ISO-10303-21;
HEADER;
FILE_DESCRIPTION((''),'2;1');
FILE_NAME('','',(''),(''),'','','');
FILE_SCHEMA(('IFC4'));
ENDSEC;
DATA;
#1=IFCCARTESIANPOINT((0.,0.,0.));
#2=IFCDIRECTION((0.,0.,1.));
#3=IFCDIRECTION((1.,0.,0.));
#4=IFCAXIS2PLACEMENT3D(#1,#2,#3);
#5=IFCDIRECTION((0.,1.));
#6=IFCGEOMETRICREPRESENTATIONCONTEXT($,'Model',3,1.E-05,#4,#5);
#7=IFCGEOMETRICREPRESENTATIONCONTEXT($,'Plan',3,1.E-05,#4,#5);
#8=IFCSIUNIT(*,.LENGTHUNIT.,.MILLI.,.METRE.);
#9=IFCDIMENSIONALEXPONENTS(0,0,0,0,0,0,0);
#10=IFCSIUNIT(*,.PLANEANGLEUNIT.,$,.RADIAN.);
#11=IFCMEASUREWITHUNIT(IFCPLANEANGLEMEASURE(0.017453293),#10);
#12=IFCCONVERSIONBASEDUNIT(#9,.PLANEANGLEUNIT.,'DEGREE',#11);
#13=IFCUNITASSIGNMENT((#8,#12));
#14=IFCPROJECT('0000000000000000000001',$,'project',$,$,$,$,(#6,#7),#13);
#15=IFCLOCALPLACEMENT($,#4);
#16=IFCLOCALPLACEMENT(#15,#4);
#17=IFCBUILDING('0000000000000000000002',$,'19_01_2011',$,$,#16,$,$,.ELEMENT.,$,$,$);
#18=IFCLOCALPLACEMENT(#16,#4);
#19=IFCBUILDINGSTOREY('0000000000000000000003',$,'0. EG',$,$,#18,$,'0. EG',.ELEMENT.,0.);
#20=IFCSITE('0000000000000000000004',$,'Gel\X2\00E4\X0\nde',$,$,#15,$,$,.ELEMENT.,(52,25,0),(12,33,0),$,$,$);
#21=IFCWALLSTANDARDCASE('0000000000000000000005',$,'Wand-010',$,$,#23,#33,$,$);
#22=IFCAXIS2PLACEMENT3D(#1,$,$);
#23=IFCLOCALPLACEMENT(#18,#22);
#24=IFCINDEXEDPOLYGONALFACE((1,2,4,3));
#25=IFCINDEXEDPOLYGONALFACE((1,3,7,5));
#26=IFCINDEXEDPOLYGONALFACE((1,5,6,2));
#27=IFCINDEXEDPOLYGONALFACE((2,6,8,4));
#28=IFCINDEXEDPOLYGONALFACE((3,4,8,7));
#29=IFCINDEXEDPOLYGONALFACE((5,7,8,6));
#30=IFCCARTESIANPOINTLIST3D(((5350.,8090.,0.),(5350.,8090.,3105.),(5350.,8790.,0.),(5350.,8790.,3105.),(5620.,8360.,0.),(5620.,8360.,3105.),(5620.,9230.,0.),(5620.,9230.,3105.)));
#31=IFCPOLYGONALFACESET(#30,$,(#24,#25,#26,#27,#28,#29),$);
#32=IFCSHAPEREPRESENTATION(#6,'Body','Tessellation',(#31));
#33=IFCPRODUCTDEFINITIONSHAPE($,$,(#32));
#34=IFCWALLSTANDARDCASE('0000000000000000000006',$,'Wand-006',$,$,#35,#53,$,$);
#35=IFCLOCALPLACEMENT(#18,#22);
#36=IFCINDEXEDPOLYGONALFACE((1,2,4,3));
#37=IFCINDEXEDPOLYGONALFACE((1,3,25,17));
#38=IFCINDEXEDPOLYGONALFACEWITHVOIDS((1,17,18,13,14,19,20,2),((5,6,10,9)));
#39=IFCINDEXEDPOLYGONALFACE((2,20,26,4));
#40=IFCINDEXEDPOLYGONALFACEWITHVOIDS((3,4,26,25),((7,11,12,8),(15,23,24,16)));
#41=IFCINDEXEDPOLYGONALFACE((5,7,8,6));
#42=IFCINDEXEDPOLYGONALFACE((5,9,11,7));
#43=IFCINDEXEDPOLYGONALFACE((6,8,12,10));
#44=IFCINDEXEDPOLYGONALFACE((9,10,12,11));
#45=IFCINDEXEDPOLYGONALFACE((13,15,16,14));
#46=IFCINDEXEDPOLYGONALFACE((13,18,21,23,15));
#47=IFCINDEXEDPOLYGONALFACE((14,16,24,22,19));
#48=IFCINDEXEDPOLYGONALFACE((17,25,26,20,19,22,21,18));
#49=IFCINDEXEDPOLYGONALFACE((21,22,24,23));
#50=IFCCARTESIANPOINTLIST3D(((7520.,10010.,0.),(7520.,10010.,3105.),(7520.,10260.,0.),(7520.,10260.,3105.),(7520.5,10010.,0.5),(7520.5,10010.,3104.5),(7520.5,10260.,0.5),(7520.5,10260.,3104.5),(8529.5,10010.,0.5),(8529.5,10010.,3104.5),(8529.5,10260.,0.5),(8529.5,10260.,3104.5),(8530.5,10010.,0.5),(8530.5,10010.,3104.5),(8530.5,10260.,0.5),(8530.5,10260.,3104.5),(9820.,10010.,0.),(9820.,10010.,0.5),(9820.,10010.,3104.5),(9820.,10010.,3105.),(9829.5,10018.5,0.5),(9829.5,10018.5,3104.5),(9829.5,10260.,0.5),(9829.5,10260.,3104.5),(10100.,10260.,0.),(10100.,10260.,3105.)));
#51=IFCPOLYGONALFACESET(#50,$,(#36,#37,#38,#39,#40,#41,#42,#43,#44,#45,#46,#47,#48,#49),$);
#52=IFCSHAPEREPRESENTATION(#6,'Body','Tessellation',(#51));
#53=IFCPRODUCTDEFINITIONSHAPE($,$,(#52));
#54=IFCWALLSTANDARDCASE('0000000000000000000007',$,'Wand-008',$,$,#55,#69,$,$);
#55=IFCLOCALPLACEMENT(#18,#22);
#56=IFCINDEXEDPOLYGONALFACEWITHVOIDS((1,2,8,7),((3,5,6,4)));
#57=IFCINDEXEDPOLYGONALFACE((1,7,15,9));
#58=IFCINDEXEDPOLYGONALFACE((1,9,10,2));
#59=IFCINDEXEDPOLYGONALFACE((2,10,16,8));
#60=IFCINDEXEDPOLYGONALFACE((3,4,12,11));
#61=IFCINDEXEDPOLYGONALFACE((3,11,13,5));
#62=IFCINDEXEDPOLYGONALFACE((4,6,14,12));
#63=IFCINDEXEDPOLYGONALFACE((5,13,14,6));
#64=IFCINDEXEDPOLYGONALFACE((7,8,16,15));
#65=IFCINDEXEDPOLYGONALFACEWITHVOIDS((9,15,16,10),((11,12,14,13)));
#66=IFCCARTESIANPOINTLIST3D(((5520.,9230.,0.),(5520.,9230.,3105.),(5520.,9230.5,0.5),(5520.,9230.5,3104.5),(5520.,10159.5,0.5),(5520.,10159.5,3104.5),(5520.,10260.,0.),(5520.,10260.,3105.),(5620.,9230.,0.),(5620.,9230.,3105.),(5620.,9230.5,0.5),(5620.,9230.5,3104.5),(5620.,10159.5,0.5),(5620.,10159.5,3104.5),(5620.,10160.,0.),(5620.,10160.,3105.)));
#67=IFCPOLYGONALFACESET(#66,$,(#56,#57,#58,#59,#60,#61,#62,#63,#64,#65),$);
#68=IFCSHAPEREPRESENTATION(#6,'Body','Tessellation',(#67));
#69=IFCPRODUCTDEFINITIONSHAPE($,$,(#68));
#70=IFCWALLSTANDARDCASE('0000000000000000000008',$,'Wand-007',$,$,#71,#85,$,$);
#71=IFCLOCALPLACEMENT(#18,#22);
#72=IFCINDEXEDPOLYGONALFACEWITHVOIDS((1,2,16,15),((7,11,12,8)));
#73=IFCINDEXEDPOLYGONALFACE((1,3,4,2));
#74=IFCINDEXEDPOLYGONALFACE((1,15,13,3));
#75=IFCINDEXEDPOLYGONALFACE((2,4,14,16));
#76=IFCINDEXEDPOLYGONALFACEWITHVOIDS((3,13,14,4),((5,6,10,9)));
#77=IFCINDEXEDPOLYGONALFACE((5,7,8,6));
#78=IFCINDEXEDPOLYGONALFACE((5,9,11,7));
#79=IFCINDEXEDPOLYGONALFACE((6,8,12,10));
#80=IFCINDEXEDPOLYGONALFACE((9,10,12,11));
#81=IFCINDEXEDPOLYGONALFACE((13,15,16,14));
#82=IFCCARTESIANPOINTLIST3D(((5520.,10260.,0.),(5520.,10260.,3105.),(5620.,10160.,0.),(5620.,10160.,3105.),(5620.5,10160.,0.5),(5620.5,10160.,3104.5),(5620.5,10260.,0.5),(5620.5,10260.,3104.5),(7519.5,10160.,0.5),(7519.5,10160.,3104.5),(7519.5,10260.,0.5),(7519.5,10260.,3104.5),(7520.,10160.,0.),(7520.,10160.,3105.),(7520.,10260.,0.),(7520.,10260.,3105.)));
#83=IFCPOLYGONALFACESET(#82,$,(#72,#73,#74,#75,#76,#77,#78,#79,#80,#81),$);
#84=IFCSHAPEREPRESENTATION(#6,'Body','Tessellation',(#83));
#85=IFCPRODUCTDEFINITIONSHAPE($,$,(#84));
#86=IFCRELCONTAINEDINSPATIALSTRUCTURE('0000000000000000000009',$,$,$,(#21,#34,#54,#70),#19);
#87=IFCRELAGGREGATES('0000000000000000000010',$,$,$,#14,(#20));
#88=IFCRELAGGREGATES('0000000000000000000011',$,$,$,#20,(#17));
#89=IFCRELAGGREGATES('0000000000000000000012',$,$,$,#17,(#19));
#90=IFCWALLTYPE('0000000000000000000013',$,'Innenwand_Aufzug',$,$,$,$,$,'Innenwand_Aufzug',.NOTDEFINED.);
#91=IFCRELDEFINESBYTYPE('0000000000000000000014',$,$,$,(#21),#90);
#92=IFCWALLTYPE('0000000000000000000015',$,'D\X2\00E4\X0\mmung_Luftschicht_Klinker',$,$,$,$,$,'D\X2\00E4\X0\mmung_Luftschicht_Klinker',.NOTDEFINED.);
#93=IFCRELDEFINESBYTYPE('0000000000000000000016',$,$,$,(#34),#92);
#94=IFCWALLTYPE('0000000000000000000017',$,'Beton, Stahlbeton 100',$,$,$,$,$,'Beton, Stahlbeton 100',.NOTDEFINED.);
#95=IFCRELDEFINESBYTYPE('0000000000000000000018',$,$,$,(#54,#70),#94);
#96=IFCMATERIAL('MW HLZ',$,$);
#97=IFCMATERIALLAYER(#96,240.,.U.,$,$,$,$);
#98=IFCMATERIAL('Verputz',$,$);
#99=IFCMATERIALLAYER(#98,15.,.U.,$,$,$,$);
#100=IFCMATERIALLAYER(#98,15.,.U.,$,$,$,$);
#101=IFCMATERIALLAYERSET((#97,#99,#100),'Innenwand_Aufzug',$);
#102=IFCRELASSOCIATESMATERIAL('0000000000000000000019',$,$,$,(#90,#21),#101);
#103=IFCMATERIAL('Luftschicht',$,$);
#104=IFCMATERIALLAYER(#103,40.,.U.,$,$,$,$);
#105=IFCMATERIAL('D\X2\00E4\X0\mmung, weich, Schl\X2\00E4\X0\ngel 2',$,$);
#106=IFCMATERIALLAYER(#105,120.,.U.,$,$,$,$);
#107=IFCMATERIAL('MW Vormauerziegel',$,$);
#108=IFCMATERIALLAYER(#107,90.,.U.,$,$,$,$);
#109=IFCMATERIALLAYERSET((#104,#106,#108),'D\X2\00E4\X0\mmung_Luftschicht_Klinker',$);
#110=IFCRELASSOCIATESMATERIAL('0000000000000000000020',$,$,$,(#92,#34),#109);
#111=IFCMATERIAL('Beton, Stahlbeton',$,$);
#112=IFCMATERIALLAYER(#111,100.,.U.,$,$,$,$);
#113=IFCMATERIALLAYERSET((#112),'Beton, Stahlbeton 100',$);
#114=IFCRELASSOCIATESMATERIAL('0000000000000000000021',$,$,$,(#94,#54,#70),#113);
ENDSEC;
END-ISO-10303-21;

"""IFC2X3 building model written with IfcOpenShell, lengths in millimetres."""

from ifc_helpers import new_model, entity, si_unit, converted_unit, direction, frame, frame_2d, origin_with_axes, place, context, project, spatial, polyline, rectangle, outline, extrude, material, layer, layer_set, layer_usage, type_object, element, save


model = new_model("IFC2X3")

# Units and contexts
model_context = context("Model", 3, precision=1e-05, world=origin_with_axes(), true_north=direction((0.0, 1.0)))
plan_context = context("Plan", 3, precision=1e-05, world=origin_with_axes(), true_north=direction((0.0, 1.0)))
ifc_project = project(units=[si_unit("LENGTHUNIT", "METRE", prefix="MILLI"), converted_unit("PLANEANGLEUNIT", "DEGREE", entity("IfcPlaneAngleMeasure", 0.017453293), si_unit("PLANEANGLEUNIT", "RADIAN"), dimensions=[0, 0, 0, 0, 0, 0, 0])], contexts=[model_context, plan_context])

# Site, building, storey
site_placement = place(None, origin_with_axes())
site = spatial("IfcSite", under=ifc_project, at=site_placement, Name="Gelände", CompositionType="ELEMENT", RefLatitude=(52, 25, 0), RefLongitude=(12, 33, 0))
building_placement = place(site_placement, origin_with_axes())
building = spatial("IfcBuilding", under=site, at=building_placement, Name="19_01_2011", CompositionType="ELEMENT")
storey_placement = place(building_placement, origin_with_axes())
storey = spatial("IfcBuildingStorey", under=building, at=storey_placement, Name="0. EG", LongName="0. EG", CompositionType="ELEMENT", Elevation=0.0)

# Shared definitions
ifc_material_1 = material(Name="Beton, Stahlbeton")

# Shared definitions
ifc_material_2 = material(Name="MW Vormauerziegel")

# Shared definitions
ifc_material_3 = material(Name="Luftschicht")
ifc_material_4 = material(Name="Verputz")
ifc_material_5 = material(Name="MW HLZ")
ifc_material_6 = material(Name="Dämmung, weich, Schlängel 2")

# Wall
ifc_layer_1 = layer(ifc_material_5, 240.0, ventilated="UNKNOWN")
ifc_layer_2 = layer(ifc_material_4, 15.0, ventilated="UNKNOWN")
ifc_layer_3 = layer(ifc_material_4, 15.0, ventilated="UNKNOWN")
ifc_layer_set_1 = layer_set([ifc_layer_1, ifc_layer_2, ifc_layer_3], Name="Innenwand_Aufzug")
wall_type_1 = type_object("IfcWallType", Name="Innenwand_Aufzug", ElementType="Innenwand_Aufzug", PredefinedType="NOTDEFINED", material=ifc_layer_set_1)
ifc_layer_usage_1 = layer_usage(ifc_layer_set_1, "AXIS2", "NEGATIVE", 0.0)
wall_1_placement = place(storey_placement, frame((5620.0, 9230.0, 0.0), z_axis=(0.0, 0.0, 1.0), x_axis=(0.0, -1.0, 0.0)))
element("IfcWallStandardCase", 1, at=wall_1_placement, inside=storey, type_object=wall_type_1, material=ifc_layer_usage_1, Name="Wand-010", context=model_context, shape_type="SweptSolid", body=[
    extrude(outline(polyline([(440.0, -270.0), (1140.0, -270.0), (870.0, 0.0), (0.0, 0.0), (440.0, -270.0)])), origin_with_axes(), (0.0, 0.0, 1.0), 3105.0),
])

# Wall, openings
ifc_layer_4 = layer(ifc_material_3, 40.0, ventilated="UNKNOWN")
ifc_layer_5 = layer(ifc_material_6, 120.0, ventilated="UNKNOWN")
ifc_layer_6 = layer(ifc_material_2, 90.0, ventilated="UNKNOWN")
ifc_layer_set_2 = layer_set([ifc_layer_4, ifc_layer_5, ifc_layer_6], Name="Dämmung_Luftschicht_Klinker")
ifc_layer_usage_2 = layer_usage(ifc_layer_set_2, "AXIS2", "POSITIVE", 0.0)
wall_type_2 = type_object("IfcWallType", Name="Dämmung_Luftschicht_Klinker", ElementType="Dämmung_Luftschicht_Klinker", PredefinedType="NOTDEFINED", material=ifc_layer_set_2)
wall_2_placement = place(storey_placement, frame((10100.0, 10260.0, 0.0), z_axis=(0.0, 0.0, 1.0), x_axis=(-1.0, 0.0, 0.0)))
wall_2 = element("IfcWallStandardCase", 2, at=wall_2_placement, inside=storey, type_object=wall_type_2, material=ifc_layer_usage_2, Name="Wand-006", context=model_context, shape_type="SweptSolid", body=[
    extrude(outline(polyline([(0.0, 0.0), (2580.0, 0.0), (2580.0, 250.0), (280.0, 250.0), (0.0, 0.0)])), origin_with_axes(), (0.0, 0.0, 1.0), 3105.0),
])
opening_1_placement = place(wall_2_placement, frame((920.0, 0.0, 0.0), z_axis=(0.0, 0.0, 1.0), x_axis=(1.0, 0.0, 0.0)))
element("IfcOpeningElement", 3, at=opening_1_placement, cuts=wall_2, ObjectType="Opening", context=model_context, shape_type="SweptSolid", body=[
    extrude(rectangle(XDim=1299.0, YDim=3104.0, at=frame_2d((0.0, 1552.5), x_axis=(1.0, 0.0))), frame((0.0, 0.0, 0.0), z_axis=(0.0, 1.0, 0.0), x_axis=(-1.0, 0.0, 0.0)), (0.0, 0.0, 1.0), 250.0),
])
opening_2_placement = place(wall_2_placement, frame((2075.0, 0.0, 0.0), z_axis=(0.0, 0.0, 1.0), x_axis=(1.0, 0.0, 0.0)))
element("IfcOpeningElement", 4, at=opening_2_placement, cuts=wall_2, ObjectType="Opening", context=model_context, shape_type="SweptSolid", body=[
    extrude(rectangle(XDim=1009.0, YDim=3104.0, at=frame_2d((0.0, 1552.5), x_axis=(1.0, 0.0))), frame((0.0, 0.0, 0.0), z_axis=(0.0, 1.0, 0.0), x_axis=(-1.0, 0.0, 0.0)), (0.0, 0.0, 1.0), 250.0),
])

# Walls, openings
ifc_layer_7 = layer(ifc_material_1, 100.0, ventilated="UNKNOWN")
ifc_layer_set_3 = layer_set([ifc_layer_7], Name="Beton, Stahlbeton 100")
ifc_layer_usage_3 = layer_usage(ifc_layer_set_3, "AXIS2", "POSITIVE", 0.0)
wall_type_3 = type_object("IfcWallType", Name="Beton, Stahlbeton 100", ElementType="Beton, Stahlbeton 100", PredefinedType="NOTDEFINED", material=ifc_layer_set_3)
wall_3_placement = place(storey_placement, frame((5520.0, 10260.0, 0.0), z_axis=(0.0, 0.0, 1.0), x_axis=(0.0, -1.0, 0.0)))
wall_3 = element("IfcWallStandardCase", 5, at=wall_3_placement, inside=storey, type_object=wall_type_3, material=ifc_layer_usage_3, Name="Wand-008", context=model_context, shape_type="SweptSolid", body=[
    extrude(outline(polyline([(0.0, 0.0), (1030.0, 0.0), (1030.0, 100.0), (100.0, 100.0), (0.0, 0.0)])), origin_with_axes(), (0.0, 0.0, 1.0), 3105.0),
])
opening_3_placement = place(wall_3_placement, frame((565.0, 0.0, 0.0), z_axis=(0.0, 0.0, 1.0), x_axis=(1.0, 0.0, 0.0)))
element("IfcOpeningElement", 6, at=opening_3_placement, cuts=wall_3, ObjectType="Opening", context=model_context, shape_type="SweptSolid", body=[
    extrude(rectangle(XDim=929.0, YDim=3104.0, at=frame_2d((0.0, 1552.5), x_axis=(1.0, 0.0))), frame((0.0, 0.0, 0.0), z_axis=(0.0, 1.0, 0.0), x_axis=(-1.0, 0.0, 0.0)), (0.0, 0.0, 1.0), 100.0),
])
ifc_layer_usage_4 = layer_usage(ifc_layer_set_3, "AXIS2", "POSITIVE", 0.0)
wall_4_placement = place(storey_placement, frame((7520.0, 10260.0, 0.0), z_axis=(0.0, 0.0, 1.0), x_axis=(-1.0, 0.0, 0.0)))
wall_4 = element("IfcWallStandardCase", 7, at=wall_4_placement, inside=storey, type_object=wall_type_3, material=ifc_layer_usage_4, Name="Wand-007", context=model_context, shape_type="SweptSolid", body=[
    extrude(outline(polyline([(0.0, 0.0), (2000.0, 0.0), (1900.0, 100.0), (0.0, 100.0), (0.0, 0.0)])), origin_with_axes(), (0.0, 0.0, 1.0), 3105.0),
])
opening_4_placement = place(wall_4_placement, frame((950.0, 0.0, 0.0), z_axis=(0.0, 0.0, 1.0), x_axis=(1.0, 0.0, 0.0)))
element("IfcOpeningElement", 8, at=opening_4_placement, cuts=wall_4, ObjectType="Opening", context=model_context, shape_type="SweptSolid", body=[
    extrude(rectangle(XDim=1899.0, YDim=3104.0, at=frame_2d((0.0, 1552.5), x_axis=(1.0, 0.0))), frame((0.0, 0.0, 0.0), z_axis=(0.0, 1.0, 0.0), x_axis=(-1.0, 0.0, 0.0)), (0.0, 0.0, 1.0), 100.0),
])

save(model, "model.ifc")
